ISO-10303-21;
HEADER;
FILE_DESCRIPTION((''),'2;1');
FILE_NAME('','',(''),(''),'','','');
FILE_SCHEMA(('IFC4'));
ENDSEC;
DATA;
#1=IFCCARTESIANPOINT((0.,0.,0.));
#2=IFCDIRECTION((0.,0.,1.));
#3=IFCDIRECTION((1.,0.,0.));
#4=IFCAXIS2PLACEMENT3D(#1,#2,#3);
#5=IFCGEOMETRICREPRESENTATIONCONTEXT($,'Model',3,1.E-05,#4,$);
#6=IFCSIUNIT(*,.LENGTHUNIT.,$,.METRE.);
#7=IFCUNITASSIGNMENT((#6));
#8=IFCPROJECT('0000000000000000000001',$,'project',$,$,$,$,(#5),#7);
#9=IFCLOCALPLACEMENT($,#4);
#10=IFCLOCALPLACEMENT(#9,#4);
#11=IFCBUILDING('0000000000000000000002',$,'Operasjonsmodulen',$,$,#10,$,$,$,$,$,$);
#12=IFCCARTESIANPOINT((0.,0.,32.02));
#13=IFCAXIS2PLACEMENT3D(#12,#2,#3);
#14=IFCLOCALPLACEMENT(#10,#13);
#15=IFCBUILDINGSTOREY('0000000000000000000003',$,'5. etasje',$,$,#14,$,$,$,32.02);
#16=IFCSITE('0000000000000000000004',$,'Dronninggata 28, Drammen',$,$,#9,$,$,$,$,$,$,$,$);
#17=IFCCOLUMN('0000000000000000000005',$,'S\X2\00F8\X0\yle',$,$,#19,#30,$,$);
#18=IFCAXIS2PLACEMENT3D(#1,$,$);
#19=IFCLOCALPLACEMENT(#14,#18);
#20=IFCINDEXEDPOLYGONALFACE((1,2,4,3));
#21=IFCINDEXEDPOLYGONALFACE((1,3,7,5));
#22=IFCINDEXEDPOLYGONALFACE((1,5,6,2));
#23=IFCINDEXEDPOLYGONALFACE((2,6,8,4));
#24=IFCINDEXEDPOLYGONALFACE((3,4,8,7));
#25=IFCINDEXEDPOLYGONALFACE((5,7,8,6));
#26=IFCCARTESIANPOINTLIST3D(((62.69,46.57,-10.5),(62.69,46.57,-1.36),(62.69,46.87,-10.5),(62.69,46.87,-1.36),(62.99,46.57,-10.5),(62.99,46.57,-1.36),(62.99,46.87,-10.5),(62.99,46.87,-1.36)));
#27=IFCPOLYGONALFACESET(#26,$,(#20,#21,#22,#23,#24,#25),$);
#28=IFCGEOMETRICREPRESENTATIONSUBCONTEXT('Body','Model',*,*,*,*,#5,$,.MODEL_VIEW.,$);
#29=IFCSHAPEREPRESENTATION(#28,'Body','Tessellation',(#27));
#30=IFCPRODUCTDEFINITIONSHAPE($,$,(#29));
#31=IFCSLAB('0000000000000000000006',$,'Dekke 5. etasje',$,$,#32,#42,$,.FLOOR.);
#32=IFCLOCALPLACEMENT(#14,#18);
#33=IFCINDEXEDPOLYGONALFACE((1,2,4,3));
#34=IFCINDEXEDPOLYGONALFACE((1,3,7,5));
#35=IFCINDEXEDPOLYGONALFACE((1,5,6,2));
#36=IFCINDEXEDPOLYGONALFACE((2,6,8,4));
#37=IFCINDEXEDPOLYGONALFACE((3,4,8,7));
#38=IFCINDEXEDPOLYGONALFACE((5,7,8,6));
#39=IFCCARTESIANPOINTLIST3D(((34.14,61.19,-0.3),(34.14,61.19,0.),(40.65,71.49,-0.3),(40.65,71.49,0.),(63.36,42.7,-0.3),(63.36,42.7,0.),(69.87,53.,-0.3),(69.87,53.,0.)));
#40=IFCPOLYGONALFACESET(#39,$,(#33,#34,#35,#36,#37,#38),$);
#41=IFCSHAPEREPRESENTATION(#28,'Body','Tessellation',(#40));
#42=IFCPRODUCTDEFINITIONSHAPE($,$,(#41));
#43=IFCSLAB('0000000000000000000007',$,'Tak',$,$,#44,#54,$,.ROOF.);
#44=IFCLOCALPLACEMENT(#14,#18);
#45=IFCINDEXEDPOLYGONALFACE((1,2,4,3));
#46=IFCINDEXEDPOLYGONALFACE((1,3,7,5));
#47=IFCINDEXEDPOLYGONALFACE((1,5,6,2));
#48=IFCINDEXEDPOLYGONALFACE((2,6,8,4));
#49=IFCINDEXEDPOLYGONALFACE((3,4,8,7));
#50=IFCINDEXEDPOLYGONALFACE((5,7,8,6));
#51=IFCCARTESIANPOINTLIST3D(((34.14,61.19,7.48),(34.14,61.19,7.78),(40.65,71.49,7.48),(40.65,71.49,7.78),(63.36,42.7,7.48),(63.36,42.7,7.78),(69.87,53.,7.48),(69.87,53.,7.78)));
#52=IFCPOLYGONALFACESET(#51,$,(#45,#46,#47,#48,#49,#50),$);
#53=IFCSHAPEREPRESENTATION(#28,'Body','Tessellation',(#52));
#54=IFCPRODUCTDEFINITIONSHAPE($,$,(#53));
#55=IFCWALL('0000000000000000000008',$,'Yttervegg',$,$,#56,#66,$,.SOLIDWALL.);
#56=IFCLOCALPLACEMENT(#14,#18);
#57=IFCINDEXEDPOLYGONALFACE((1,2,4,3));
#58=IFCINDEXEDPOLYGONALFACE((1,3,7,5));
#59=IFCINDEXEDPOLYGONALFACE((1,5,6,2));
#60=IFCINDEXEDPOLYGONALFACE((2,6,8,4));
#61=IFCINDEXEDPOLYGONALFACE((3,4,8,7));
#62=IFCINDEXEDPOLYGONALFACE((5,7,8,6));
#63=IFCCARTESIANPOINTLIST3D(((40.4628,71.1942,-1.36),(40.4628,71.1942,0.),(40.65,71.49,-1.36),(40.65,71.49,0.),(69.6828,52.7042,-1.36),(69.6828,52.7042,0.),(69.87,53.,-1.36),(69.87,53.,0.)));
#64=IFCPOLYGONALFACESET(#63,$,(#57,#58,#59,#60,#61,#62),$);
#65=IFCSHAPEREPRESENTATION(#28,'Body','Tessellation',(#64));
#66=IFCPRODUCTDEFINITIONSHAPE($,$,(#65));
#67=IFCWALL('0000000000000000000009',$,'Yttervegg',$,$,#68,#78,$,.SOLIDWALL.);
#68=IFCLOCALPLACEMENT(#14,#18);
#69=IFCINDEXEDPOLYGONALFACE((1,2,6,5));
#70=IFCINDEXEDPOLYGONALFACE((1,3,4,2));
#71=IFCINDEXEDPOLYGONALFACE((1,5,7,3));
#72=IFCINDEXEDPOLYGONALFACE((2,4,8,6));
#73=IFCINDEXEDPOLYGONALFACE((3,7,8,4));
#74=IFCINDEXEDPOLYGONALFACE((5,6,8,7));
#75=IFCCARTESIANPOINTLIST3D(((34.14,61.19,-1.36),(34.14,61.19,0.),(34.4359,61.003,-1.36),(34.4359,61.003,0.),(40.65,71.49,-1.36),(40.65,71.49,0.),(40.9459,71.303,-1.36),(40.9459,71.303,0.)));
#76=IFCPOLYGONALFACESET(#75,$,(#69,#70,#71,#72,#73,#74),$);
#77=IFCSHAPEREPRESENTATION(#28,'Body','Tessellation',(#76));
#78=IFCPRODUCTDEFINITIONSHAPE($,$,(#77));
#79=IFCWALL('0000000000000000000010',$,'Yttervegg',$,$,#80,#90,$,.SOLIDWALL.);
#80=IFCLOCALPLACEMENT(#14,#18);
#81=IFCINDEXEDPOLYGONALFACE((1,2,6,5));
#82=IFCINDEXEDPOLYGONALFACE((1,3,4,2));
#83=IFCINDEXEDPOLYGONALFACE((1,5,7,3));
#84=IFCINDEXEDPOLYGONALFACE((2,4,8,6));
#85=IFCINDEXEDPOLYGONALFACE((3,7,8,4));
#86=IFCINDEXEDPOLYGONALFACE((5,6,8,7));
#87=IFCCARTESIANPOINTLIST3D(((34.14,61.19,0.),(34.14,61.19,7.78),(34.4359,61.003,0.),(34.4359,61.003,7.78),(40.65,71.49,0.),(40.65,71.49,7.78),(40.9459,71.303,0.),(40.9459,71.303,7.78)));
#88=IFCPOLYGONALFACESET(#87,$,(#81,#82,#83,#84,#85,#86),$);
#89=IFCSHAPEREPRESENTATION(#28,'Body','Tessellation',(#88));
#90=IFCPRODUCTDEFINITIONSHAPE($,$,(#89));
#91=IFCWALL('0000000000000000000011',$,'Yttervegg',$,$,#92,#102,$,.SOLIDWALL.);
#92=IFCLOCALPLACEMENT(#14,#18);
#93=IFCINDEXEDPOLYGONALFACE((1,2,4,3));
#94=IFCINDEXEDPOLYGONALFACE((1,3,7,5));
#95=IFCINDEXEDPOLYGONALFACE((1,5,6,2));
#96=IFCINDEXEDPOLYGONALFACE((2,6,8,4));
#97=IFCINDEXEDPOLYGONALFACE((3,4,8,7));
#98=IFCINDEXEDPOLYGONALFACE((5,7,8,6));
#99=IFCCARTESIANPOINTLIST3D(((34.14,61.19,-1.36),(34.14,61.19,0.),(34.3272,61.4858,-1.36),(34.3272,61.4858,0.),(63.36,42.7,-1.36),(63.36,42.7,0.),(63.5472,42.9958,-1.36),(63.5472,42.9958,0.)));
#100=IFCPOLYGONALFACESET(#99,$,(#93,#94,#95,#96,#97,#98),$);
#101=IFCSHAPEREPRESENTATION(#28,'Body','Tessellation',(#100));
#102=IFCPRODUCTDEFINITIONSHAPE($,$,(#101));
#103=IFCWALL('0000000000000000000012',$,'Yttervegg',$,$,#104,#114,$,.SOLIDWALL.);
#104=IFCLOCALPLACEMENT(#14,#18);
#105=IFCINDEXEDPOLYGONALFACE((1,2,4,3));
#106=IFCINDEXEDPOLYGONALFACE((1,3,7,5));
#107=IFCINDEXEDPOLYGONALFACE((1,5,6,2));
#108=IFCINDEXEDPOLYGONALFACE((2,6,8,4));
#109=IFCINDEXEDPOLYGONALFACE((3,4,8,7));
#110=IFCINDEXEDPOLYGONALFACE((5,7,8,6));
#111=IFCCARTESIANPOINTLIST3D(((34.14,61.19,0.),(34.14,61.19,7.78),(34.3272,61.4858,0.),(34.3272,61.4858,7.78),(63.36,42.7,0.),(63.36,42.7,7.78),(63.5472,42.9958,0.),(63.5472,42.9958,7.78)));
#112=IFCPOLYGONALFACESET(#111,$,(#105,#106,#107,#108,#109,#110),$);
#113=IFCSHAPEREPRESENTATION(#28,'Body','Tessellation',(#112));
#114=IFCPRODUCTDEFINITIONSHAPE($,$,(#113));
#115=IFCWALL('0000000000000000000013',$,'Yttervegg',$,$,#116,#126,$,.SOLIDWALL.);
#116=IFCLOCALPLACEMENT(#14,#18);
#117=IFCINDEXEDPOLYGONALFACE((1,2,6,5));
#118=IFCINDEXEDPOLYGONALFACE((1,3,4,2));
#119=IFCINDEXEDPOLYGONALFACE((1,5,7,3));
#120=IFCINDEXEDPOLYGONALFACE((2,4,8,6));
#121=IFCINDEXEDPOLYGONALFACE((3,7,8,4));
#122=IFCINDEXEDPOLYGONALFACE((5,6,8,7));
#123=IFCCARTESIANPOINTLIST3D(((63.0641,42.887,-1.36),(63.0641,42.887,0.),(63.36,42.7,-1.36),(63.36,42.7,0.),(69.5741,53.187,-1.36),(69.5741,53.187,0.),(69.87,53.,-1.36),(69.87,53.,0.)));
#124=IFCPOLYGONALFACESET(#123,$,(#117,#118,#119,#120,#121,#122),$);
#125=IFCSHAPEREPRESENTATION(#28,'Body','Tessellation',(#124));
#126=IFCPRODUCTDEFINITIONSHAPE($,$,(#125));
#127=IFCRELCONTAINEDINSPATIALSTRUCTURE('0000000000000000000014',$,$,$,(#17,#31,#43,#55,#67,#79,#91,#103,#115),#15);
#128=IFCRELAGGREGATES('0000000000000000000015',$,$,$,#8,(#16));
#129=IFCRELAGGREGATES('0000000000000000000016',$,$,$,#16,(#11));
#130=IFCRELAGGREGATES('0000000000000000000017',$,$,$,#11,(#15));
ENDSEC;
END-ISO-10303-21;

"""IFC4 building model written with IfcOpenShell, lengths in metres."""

from ifc_helpers import new_model, si_unit, frame, origin_with_axes, place, context, subcontext, project, spatial, polyline, outline, extrude, element, save


model = new_model("IFC4")

# Units and contexts
model_context = context("Model", 3, precision=1e-05, world=origin_with_axes())
body_context = subcontext(model_context, "Body", "Model", "MODEL_VIEW")
ifc_project = project(units=[si_unit("LENGTHUNIT", "METRE")], contexts=[model_context])

# Site, building, storey
site_placement = place(None, origin_with_axes())
site = spatial("IfcSite", under=ifc_project, at=site_placement, Name="Dronninggata 28, Drammen")
building_placement = place(site_placement, origin_with_axes())
building = spatial("IfcBuilding", under=site, at=building_placement, Name="Operasjonsmodulen")
storey_placement = place(building_placement, frame((0.0, 0.0, 32.02), z_axis=(0.0, 0.0, 1.0), x_axis=(1.0, 0.0, 0.0)))
storey = spatial("IfcBuildingStorey", under=building, at=storey_placement, Name="5. etasje", Elevation=32.02)

# Column
column_placement = place(storey_placement, frame((0.0, 0.0, -32.02), z_axis=(0.0, 0.0, 1.0), x_axis=(1.0, 0.0, 0.0)))
element("IfcColumn", 1, at=column_placement, inside=storey, Name="Søyle", context=body_context, shape_type="SweptSolid", body=[
    extrude(outline(polyline([(62.69, 46.57), (62.99, 46.57), (62.99, 46.87), (62.69, 46.87), (62.69, 46.57)])), frame((0.0, 0.0, 21.52)), (0.0, 0.0, 1.0), 9.14),
])

# Slabs
slab_1_placement = place(storey_placement, frame((0.0, 0.0, -32.02), z_axis=(0.0, 0.0, 1.0), x_axis=(1.0, 0.0, 0.0)))
element("IfcSlab", 2, at=slab_1_placement, inside=storey, Name="Dekke 5. etasje", PredefinedType="FLOOR", context=body_context, shape_type="SweptSolid", body=[
    extrude(outline(polyline([(69.87, 53.0), (40.65, 71.49), (34.14, 61.19), (63.36, 42.7), (69.87, 53.0)])), frame((0.0, 0.0, 31.72)), (0.0, 0.0, 1.0), 0.3),
])
slab_2_placement = place(storey_placement, frame((0.0, 0.0, -32.02), z_axis=(0.0, 0.0, 1.0), x_axis=(1.0, 0.0, 0.0)))
element("IfcSlab", 3, at=slab_2_placement, inside=storey, Name="Tak", PredefinedType="ROOF", context=body_context, shape_type="SweptSolid", body=[
    extrude(outline(polyline([(69.87, 53.0), (40.65, 71.49), (34.14, 61.19), (63.36, 42.7), (69.87, 53.0)])), frame((0.0, 0.0, 39.5)), (0.0, 0.0, 1.0), 0.3),
])

# Wall
wall_1_placement = place(storey_placement, frame((0.0, 0.0, -32.02), z_axis=(0.0, 0.0, 1.0), x_axis=(1.0, 0.0, 0.0)))
element("IfcWall", 4, at=wall_1_placement, inside=storey, Name="Yttervegg", PredefinedType="SOLIDWALL", context=body_context, shape_type="SweptSolid", body=[
    extrude(outline(polyline([(69.87, 53.0), (40.65, 71.49), (40.4628, 71.1942), (69.6828, 52.7042), (69.87, 53.0)])), frame((0.0, 0.0, 30.66)), (0.0, 0.0, 1.0), 1.36),
])

# Walls
wall_2_placement = place(storey_placement, frame((0.0, 0.0, -32.02), z_axis=(0.0, 0.0, 1.0), x_axis=(1.0, 0.0, 0.0)))
element("IfcWall", 5, at=wall_2_placement, inside=storey, Name="Yttervegg", PredefinedType="SOLIDWALL", context=body_context, shape_type="SweptSolid", body=[
    extrude(outline(polyline([(40.65, 71.49), (34.14, 61.19), (34.4359, 61.003), (40.9459, 71.303), (40.65, 71.49)])), frame((0.0, 0.0, 30.66)), (0.0, 0.0, 1.0), 1.36),
])
wall_3_placement = place(storey_placement, frame((0.0, 0.0, -32.02), z_axis=(0.0, 0.0, 1.0), x_axis=(1.0, 0.0, 0.0)))
element("IfcWall", 6, at=wall_3_placement, inside=storey, Name="Yttervegg", PredefinedType="SOLIDWALL", context=body_context, shape_type="SweptSolid", body=[
    extrude(outline(polyline([(40.65, 71.49), (34.14, 61.19), (34.4359, 61.003), (40.9459, 71.303), (40.65, 71.49)])), frame((0.0, 0.0, 32.02)), (0.0, 0.0, 1.0), 7.78),
])
wall_4_placement = place(storey_placement, frame((0.0, 0.0, -32.02), z_axis=(0.0, 0.0, 1.0), x_axis=(1.0, 0.0, 0.0)))
element("IfcWall", 7, at=wall_4_placement, inside=storey, Name="Yttervegg", PredefinedType="SOLIDWALL", context=body_context, shape_type="SweptSolid", body=[
    extrude(outline(polyline([(34.14, 61.19), (63.36, 42.7), (63.5472, 42.9958), (34.3272, 61.4858), (34.14, 61.19)])), frame((0.0, 0.0, 30.66)), (0.0, 0.0, 1.0), 1.36),
])
wall_5_placement = place(storey_placement, frame((0.0, 0.0, -32.02), z_axis=(0.0, 0.0, 1.0), x_axis=(1.0, 0.0, 0.0)))
element("IfcWall", 8, at=wall_5_placement, inside=storey, Name="Yttervegg", PredefinedType="SOLIDWALL", context=body_context, shape_type="SweptSolid", body=[
    extrude(outline(polyline([(34.14, 61.19), (63.36, 42.7), (63.5472, 42.9958), (34.3272, 61.4858), (34.14, 61.19)])), frame((0.0, 0.0, 32.02)), (0.0, 0.0, 1.0), 7.78),
])
wall_6_placement = place(storey_placement, frame((0.0, 0.0, -32.02), z_axis=(0.0, 0.0, 1.0), x_axis=(1.0, 0.0, 0.0)))
element("IfcWall", 9, at=wall_6_placement, inside=storey, Name="Yttervegg", PredefinedType="SOLIDWALL", context=body_context, shape_type="SweptSolid", body=[
    extrude(outline(polyline([(63.36, 42.7), (69.87, 53.0), (69.5741, 53.187), (63.0641, 42.887), (63.36, 42.7)])), frame((0.0, 0.0, 30.66)), (0.0, 0.0, 1.0), 1.36),
])

save(model, "model.ifc")
